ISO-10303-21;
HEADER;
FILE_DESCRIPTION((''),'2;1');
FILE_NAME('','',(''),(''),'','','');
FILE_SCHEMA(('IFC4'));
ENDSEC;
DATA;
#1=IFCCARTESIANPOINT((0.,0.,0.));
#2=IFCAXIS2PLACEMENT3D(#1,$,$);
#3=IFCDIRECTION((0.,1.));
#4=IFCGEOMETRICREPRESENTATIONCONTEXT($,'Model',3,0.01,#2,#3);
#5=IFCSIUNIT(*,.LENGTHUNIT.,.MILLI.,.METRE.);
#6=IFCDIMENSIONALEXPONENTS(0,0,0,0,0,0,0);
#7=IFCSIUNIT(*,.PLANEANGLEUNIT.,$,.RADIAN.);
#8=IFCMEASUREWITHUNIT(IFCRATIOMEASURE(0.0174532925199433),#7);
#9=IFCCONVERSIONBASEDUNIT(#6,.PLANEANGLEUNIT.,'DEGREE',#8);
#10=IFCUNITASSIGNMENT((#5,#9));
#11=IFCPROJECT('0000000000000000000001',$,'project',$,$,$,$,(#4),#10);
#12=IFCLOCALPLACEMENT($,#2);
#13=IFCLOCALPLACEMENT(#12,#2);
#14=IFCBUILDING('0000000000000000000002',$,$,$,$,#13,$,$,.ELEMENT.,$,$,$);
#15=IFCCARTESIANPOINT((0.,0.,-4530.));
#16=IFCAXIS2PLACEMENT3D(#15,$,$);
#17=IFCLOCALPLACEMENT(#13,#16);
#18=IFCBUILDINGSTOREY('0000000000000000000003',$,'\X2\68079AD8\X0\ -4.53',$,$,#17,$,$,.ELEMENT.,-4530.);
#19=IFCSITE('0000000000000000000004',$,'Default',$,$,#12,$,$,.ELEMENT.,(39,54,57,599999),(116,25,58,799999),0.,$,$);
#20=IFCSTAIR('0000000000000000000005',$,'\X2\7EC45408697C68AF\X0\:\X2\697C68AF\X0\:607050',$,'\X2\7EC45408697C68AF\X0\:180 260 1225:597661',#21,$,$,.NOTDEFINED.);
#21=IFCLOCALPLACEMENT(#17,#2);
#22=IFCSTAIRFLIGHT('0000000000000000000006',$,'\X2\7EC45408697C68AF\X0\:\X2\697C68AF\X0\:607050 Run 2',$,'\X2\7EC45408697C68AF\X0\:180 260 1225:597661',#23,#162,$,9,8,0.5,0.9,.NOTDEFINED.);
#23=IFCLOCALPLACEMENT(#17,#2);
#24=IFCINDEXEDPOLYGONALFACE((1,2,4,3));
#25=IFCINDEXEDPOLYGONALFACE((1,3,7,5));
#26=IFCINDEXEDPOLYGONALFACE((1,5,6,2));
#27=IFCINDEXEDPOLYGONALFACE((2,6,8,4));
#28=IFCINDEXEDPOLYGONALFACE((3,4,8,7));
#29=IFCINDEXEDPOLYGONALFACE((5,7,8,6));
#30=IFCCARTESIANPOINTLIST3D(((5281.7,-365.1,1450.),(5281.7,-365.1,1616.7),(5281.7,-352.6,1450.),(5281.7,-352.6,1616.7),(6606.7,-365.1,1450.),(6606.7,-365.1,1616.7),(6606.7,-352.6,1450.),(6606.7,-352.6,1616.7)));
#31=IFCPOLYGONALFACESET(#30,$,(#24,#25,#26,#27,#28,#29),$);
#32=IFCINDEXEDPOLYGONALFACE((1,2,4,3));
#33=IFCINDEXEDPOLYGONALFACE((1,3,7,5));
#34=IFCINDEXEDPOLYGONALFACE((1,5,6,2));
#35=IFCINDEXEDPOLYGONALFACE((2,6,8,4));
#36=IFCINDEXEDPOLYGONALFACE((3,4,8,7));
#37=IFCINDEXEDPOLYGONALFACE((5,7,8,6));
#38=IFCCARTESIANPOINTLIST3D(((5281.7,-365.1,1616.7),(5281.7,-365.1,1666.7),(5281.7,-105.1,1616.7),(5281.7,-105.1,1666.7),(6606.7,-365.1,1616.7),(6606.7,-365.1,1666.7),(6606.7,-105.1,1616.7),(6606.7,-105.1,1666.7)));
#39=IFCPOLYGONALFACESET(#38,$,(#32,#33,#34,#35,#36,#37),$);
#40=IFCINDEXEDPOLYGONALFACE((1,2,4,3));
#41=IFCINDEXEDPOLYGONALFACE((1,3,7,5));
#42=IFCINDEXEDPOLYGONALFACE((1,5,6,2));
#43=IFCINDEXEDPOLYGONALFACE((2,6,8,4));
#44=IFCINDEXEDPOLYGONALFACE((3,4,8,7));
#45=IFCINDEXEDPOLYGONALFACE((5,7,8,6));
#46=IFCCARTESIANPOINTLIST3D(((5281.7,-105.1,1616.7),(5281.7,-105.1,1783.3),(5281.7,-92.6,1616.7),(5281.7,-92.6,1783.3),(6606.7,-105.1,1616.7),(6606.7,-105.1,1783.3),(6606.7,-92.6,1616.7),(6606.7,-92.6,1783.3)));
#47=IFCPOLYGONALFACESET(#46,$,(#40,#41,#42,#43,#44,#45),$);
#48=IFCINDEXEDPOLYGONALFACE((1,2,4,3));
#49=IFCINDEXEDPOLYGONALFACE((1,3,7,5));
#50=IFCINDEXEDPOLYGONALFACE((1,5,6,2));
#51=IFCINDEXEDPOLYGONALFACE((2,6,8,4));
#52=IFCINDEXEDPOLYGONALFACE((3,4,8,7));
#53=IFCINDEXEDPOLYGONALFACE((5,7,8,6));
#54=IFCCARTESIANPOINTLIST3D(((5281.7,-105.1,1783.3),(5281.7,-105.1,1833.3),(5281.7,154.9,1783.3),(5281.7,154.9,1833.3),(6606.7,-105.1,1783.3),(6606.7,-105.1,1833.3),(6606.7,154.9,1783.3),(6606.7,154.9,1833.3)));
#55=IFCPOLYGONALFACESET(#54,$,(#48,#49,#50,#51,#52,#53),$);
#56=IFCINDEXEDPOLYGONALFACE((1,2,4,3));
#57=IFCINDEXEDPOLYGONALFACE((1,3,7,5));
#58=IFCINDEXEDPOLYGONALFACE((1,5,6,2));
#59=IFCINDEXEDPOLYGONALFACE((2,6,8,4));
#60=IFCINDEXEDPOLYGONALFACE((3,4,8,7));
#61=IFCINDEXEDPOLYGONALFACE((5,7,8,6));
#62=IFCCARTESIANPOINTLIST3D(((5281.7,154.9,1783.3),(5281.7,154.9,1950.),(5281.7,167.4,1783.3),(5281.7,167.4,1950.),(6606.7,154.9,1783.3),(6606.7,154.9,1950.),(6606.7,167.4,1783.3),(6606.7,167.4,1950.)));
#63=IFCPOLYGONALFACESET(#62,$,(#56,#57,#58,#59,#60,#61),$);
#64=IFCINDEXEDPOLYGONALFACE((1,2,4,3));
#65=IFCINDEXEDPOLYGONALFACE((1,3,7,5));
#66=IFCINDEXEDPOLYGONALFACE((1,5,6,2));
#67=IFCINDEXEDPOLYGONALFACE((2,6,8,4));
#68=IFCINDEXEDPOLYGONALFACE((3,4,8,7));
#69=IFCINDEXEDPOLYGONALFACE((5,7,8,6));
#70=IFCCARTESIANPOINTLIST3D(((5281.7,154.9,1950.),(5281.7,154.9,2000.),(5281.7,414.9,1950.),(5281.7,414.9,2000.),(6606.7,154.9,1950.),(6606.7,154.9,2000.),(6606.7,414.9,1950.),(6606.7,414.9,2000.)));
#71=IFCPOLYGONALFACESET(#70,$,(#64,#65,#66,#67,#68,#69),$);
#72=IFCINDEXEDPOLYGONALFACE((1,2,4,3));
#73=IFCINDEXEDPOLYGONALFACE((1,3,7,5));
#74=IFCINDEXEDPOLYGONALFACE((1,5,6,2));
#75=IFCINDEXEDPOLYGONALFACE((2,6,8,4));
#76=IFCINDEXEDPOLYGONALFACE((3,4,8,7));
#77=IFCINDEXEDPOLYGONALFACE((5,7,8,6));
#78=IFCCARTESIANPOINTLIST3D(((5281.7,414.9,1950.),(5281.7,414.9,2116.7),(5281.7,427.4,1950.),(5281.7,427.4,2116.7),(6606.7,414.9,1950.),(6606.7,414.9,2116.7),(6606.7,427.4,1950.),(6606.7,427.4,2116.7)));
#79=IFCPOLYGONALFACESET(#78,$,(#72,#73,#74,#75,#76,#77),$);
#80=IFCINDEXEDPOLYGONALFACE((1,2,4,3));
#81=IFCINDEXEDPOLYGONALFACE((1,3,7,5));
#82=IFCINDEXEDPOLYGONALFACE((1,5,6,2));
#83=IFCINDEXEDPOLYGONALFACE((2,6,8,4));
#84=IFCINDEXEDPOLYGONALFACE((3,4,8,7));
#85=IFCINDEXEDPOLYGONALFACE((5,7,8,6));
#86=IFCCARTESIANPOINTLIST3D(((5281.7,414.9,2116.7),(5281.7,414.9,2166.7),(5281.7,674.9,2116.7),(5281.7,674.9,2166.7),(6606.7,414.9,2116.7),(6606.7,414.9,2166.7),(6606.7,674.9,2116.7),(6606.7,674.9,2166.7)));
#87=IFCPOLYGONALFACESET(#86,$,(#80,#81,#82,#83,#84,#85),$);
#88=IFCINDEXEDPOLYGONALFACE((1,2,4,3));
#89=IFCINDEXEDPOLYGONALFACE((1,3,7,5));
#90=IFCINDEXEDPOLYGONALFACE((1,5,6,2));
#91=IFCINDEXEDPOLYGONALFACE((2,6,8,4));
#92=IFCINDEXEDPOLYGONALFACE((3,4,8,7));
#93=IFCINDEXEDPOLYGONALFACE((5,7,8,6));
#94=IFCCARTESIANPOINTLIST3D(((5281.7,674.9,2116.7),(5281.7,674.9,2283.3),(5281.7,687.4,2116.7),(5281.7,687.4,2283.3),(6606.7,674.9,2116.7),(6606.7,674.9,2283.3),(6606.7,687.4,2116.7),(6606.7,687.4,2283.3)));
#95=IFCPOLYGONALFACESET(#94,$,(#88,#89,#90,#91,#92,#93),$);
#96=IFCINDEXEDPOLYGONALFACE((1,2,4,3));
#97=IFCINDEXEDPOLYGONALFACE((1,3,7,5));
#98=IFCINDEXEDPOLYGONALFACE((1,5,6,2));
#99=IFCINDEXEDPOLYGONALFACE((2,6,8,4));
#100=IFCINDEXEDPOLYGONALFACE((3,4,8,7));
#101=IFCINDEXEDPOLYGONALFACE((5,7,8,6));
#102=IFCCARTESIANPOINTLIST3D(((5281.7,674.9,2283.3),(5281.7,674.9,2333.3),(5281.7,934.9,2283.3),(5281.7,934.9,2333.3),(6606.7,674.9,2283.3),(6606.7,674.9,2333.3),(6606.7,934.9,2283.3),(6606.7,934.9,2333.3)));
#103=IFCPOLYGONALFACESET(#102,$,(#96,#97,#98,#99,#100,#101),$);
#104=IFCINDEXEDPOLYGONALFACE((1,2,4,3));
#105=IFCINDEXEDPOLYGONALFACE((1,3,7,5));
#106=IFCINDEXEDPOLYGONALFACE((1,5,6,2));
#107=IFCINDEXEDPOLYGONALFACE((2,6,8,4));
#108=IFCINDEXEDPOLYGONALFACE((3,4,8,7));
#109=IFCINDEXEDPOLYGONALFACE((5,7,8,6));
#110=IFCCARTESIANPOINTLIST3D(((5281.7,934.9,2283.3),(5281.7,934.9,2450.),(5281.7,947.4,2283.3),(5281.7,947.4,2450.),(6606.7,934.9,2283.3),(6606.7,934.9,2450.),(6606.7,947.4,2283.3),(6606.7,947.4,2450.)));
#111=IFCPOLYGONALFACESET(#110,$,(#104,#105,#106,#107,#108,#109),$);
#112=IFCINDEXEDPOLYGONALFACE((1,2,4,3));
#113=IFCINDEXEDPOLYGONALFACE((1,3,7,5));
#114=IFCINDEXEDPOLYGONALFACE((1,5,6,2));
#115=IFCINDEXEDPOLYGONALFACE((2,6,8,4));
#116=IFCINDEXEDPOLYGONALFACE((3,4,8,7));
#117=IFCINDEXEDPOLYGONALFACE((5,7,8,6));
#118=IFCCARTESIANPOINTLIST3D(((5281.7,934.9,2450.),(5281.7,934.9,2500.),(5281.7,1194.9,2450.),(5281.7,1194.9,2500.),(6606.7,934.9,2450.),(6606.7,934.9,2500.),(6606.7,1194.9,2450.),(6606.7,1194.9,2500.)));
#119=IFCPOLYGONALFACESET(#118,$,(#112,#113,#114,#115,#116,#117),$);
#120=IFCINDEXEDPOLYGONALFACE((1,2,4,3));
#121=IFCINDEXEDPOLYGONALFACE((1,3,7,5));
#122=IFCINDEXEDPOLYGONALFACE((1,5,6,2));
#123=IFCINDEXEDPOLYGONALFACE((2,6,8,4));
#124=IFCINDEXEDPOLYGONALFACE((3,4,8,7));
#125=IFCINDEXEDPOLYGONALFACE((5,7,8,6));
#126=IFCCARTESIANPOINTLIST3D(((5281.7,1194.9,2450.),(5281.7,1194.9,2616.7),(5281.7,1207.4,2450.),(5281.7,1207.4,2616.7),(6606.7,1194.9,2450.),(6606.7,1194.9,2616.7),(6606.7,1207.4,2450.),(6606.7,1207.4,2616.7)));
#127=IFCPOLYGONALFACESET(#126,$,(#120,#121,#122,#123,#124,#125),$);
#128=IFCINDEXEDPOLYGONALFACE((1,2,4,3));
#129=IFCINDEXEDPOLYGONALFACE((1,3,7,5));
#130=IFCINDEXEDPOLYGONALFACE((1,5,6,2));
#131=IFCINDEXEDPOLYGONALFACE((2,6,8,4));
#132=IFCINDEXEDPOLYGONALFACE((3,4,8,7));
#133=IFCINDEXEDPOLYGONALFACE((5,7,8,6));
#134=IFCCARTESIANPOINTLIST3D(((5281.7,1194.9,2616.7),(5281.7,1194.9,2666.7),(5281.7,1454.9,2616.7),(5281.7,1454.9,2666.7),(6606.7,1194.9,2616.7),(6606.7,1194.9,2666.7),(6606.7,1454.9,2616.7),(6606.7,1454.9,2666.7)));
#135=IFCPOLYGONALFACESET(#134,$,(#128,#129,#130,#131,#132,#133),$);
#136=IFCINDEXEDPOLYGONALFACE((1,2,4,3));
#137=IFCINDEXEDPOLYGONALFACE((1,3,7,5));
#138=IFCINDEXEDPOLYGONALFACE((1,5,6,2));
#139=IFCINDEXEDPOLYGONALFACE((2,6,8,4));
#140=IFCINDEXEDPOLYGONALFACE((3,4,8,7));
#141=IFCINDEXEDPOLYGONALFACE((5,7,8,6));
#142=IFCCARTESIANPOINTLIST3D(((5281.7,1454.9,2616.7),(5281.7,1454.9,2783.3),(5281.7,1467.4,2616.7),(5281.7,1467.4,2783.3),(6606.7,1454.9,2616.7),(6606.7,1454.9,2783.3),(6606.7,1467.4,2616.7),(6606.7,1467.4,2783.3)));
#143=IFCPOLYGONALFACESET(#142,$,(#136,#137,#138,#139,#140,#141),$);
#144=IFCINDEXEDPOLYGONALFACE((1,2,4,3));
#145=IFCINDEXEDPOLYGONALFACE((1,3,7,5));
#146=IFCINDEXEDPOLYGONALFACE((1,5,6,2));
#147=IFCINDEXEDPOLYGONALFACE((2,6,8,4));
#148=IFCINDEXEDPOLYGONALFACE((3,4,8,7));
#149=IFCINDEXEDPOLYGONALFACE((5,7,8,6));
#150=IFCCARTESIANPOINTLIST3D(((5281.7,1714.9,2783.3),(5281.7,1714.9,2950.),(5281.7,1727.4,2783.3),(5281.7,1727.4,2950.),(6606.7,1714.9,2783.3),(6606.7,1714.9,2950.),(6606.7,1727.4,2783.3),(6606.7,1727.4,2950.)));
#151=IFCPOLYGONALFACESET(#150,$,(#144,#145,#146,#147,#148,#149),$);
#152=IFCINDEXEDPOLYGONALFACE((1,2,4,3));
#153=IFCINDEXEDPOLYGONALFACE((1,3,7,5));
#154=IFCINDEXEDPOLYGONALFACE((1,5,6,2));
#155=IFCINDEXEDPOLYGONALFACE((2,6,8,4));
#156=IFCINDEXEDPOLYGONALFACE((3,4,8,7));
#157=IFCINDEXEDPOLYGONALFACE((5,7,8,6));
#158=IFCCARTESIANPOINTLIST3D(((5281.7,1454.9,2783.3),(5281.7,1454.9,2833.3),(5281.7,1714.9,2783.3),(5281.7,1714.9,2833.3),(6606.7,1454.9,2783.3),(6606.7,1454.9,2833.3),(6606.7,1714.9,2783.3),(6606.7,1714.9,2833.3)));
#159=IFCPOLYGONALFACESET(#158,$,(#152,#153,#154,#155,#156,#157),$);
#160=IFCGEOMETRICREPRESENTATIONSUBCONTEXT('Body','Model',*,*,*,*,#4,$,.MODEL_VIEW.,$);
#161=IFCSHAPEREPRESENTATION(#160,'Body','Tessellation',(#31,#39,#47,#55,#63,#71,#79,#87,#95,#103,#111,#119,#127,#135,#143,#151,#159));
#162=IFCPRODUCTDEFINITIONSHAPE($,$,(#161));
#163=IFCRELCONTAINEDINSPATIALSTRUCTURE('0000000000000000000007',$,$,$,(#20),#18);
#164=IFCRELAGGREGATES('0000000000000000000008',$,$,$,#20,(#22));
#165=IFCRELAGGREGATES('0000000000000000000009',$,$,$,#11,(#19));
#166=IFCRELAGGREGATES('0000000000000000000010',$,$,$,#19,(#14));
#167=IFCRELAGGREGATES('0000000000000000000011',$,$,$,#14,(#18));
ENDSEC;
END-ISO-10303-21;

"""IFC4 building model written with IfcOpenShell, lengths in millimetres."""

from ifc_helpers import new_model, entity, si_unit, converted_unit, direction, frame, frame_2d, origin, origin_2d_with_axis, place, context, subcontext, project, spatial, rectangle, extrude, element, aggregate, save


model = new_model("IFC4")

# Units and contexts
model_context = context("Model", 3, precision=0.01, world=origin(), true_north=direction((0.0, 1.0)))
body_context = subcontext(model_context, "Body", "Model", "MODEL_VIEW")
ifc_project = project(units=[si_unit("LENGTHUNIT", "METRE", prefix="MILLI"), converted_unit("PLANEANGLEUNIT", "DEGREE", entity("IfcRatioMeasure", 0.0174532925199433), si_unit("PLANEANGLEUNIT", "RADIAN"), dimensions=[0, 0, 0, 0, 0, 0, 0])], contexts=[model_context])

# Site, building, storey
site_placement = place(None, origin())
site = spatial("IfcSite", under=ifc_project, at=site_placement, Name="Default", CompositionType="ELEMENT", RefLatitude=(39, 54, 57, 599999), RefLongitude=(116, 25, 58, 799999), RefElevation=0.0)
building_placement = place(site_placement, origin())
building = spatial("IfcBuilding", under=site, at=building_placement, CompositionType="ELEMENT")
storey_placement = place(building_placement, frame((0.0, 0.0, -4530.0)))
storey = spatial("IfcBuildingStorey", under=building, at=storey_placement, Name="标高 -4.53", CompositionType="ELEMENT", Elevation=-4530.0)

# Stair, stair flight
stair_placement = place(storey_placement, origin())
stair = element("IfcStair", 1, at=stair_placement, inside=storey, Name="组合楼梯:楼梯:607050", ObjectType="组合楼梯:180 260 1225:597661", PredefinedType="NOTDEFINED")
stair_flight_1_placement = place(stair_placement, frame((5281.7, -365.1, 0.0)))
stair_flight_1 = element("IfcStairFlight", 2, at=stair_flight_1_placement, Name="组合楼梯:楼梯:607050 Run 2", ObjectType="组合楼梯:180 260 1225:597661", NumberOfRisers=9, NumberOfTreads=8, PredefinedType="NOTDEFINED", RiserHeight=0.5, TreadLength=0.9, context=body_context, shape_type="SweptSolid", body=[
    extrude(rectangle(XDim=1325.0, YDim=12.5, at=origin_2d_with_axis()), frame((662.5, 6.2, 1450.0), z_axis=(0.0, 0.0, 1.0), x_axis=(-1.0, 0.0, 0.0)), (0.0, 0.0, 1.0), 166.7),
    extrude(rectangle(XDim=260.0, YDim=1325.0, at=frame_2d((0.0, 0.0), x_axis=(1.0, 0.0))), frame((662.5, 130.0, 1616.7), z_axis=(0.0, 0.0, 1.0), x_axis=(0.0, -1.0, 0.0)), (0.0, 0.0, 1.0), 50.0),
    extrude(rectangle(XDim=1325.0, YDim=12.5, at=origin_2d_with_axis()), frame((662.5, 266.2, 1616.7), z_axis=(0.0, 0.0, 1.0), x_axis=(-1.0, 0.0, 0.0)), (0.0, 0.0, 1.0), 166.7),
    extrude(rectangle(XDim=260.0, YDim=1325.0, at=frame_2d((0.0, 0.0), x_axis=(1.0, 0.0))), frame((662.5, 390.0, 1783.3), z_axis=(0.0, 0.0, 1.0), x_axis=(0.0, -1.0, 0.0)), (0.0, 0.0, 1.0), 50.0),
    extrude(rectangle(XDim=1325.0, YDim=12.5, at=origin_2d_with_axis()), frame((662.5, 526.2, 1783.3), z_axis=(0.0, 0.0, 1.0), x_axis=(-1.0, 0.0, 0.0)), (0.0, 0.0, 1.0), 166.7),
    extrude(rectangle(XDim=260.0, YDim=1325.0, at=frame_2d((0.0, 0.0), x_axis=(1.0, 0.0))), frame((662.5, 650.0, 1950.0), z_axis=(0.0, 0.0, 1.0), x_axis=(0.0, -1.0, 0.0)), (0.0, 0.0, 1.0), 50.0),
    extrude(rectangle(XDim=1325.0, YDim=12.5, at=frame_2d((0.0, 0.0), x_axis=(1.0, 0.0))), frame((662.5, 786.2, 1950.0), z_axis=(0.0, 0.0, 1.0), x_axis=(-1.0, 0.0, 0.0)), (0.0, 0.0, 1.0), 166.7),
    extrude(rectangle(XDim=260.0, YDim=1325.0, at=frame_2d((0.0, 0.0), x_axis=(1.0, 0.0))), frame((662.5, 910.0, 2116.7), z_axis=(0.0, 0.0, 1.0), x_axis=(0.0, -1.0, 0.0)), (0.0, 0.0, 1.0), 50.0),
    extrude(rectangle(XDim=1325.0, YDim=12.5, at=frame_2d((0.0, 0.0), x_axis=(1.0, 0.0))), frame((662.5, 1046.2, 2116.7), z_axis=(0.0, 0.0, 1.0), x_axis=(-1.0, 0.0, 0.0)), (0.0, 0.0, 1.0), 166.7),
    extrude(rectangle(XDim=260.0, YDim=1325.0, at=frame_2d((0.0, 0.0), x_axis=(1.0, 0.0))), frame((662.5, 1170.0, 2283.3), z_axis=(0.0, 0.0, 1.0), x_axis=(0.0, -1.0, 0.0)), (0.0, 0.0, 1.0), 50.0),
    extrude(rectangle(XDim=1325.0, YDim=12.5, at=frame_2d((0.0, 0.0), x_axis=(1.0, 0.0))), frame((662.5, 1306.2, 2283.3), z_axis=(0.0, 0.0, 1.0), x_axis=(-1.0, 0.0, 0.0)), (0.0, 0.0, 1.0), 166.7),
    extrude(rectangle(XDim=260.0, YDim=1325.0, at=frame_2d((0.0, 0.0), x_axis=(1.0, 0.0))), frame((662.5, 1430.0, 2450.0), z_axis=(0.0, 0.0, 1.0), x_axis=(0.0, -1.0, 0.0)), (0.0, 0.0, 1.0), 50.0),
    extrude(rectangle(XDim=1325.0, YDim=12.5, at=frame_2d((0.0, 0.0), x_axis=(1.0, 0.0))), frame((662.5, 1566.2, 2450.0), z_axis=(0.0, 0.0, 1.0), x_axis=(-1.0, 0.0, 0.0)), (0.0, 0.0, 1.0), 166.7),
    extrude(rectangle(XDim=260.0, YDim=1325.0, at=frame_2d((0.0, 0.0), x_axis=(1.0, 0.0))), frame((662.5, 1690.0, 2616.7), z_axis=(0.0, 0.0, 1.0), x_axis=(0.0, -1.0, 0.0)), (0.0, 0.0, 1.0), 50.0),
    extrude(rectangle(XDim=1325.0, YDim=12.5, at=frame_2d((0.0, 0.0), x_axis=(1.0, 0.0))), frame((662.5, 1826.2, 2616.7), z_axis=(0.0, 0.0, 1.0), x_axis=(-1.0, 0.0, 0.0)), (0.0, 0.0, 1.0), 166.7),
    extrude(rectangle(XDim=1325.0, YDim=12.5, at=frame_2d((0.0, 0.0), x_axis=(1.0, 0.0))), frame((662.5, 2086.2, 2783.3), z_axis=(0.0, 0.0, 1.0), x_axis=(-1.0, 0.0, 0.0)), (0.0, 0.0, 1.0), 166.7),
    extrude(rectangle(XDim=260.0, YDim=1325.0, at=frame_2d((0.0, 0.0), x_axis=(1.0, 0.0))), frame((662.5, 1950.0, 2783.3), z_axis=(0.0, 0.0, 1.0), x_axis=(0.0, -1.0, 0.0)), (0.0, 0.0, 1.0), 50.0),
])
aggregate(stair, [stair_flight_1])

save(model, "model.ifc")
